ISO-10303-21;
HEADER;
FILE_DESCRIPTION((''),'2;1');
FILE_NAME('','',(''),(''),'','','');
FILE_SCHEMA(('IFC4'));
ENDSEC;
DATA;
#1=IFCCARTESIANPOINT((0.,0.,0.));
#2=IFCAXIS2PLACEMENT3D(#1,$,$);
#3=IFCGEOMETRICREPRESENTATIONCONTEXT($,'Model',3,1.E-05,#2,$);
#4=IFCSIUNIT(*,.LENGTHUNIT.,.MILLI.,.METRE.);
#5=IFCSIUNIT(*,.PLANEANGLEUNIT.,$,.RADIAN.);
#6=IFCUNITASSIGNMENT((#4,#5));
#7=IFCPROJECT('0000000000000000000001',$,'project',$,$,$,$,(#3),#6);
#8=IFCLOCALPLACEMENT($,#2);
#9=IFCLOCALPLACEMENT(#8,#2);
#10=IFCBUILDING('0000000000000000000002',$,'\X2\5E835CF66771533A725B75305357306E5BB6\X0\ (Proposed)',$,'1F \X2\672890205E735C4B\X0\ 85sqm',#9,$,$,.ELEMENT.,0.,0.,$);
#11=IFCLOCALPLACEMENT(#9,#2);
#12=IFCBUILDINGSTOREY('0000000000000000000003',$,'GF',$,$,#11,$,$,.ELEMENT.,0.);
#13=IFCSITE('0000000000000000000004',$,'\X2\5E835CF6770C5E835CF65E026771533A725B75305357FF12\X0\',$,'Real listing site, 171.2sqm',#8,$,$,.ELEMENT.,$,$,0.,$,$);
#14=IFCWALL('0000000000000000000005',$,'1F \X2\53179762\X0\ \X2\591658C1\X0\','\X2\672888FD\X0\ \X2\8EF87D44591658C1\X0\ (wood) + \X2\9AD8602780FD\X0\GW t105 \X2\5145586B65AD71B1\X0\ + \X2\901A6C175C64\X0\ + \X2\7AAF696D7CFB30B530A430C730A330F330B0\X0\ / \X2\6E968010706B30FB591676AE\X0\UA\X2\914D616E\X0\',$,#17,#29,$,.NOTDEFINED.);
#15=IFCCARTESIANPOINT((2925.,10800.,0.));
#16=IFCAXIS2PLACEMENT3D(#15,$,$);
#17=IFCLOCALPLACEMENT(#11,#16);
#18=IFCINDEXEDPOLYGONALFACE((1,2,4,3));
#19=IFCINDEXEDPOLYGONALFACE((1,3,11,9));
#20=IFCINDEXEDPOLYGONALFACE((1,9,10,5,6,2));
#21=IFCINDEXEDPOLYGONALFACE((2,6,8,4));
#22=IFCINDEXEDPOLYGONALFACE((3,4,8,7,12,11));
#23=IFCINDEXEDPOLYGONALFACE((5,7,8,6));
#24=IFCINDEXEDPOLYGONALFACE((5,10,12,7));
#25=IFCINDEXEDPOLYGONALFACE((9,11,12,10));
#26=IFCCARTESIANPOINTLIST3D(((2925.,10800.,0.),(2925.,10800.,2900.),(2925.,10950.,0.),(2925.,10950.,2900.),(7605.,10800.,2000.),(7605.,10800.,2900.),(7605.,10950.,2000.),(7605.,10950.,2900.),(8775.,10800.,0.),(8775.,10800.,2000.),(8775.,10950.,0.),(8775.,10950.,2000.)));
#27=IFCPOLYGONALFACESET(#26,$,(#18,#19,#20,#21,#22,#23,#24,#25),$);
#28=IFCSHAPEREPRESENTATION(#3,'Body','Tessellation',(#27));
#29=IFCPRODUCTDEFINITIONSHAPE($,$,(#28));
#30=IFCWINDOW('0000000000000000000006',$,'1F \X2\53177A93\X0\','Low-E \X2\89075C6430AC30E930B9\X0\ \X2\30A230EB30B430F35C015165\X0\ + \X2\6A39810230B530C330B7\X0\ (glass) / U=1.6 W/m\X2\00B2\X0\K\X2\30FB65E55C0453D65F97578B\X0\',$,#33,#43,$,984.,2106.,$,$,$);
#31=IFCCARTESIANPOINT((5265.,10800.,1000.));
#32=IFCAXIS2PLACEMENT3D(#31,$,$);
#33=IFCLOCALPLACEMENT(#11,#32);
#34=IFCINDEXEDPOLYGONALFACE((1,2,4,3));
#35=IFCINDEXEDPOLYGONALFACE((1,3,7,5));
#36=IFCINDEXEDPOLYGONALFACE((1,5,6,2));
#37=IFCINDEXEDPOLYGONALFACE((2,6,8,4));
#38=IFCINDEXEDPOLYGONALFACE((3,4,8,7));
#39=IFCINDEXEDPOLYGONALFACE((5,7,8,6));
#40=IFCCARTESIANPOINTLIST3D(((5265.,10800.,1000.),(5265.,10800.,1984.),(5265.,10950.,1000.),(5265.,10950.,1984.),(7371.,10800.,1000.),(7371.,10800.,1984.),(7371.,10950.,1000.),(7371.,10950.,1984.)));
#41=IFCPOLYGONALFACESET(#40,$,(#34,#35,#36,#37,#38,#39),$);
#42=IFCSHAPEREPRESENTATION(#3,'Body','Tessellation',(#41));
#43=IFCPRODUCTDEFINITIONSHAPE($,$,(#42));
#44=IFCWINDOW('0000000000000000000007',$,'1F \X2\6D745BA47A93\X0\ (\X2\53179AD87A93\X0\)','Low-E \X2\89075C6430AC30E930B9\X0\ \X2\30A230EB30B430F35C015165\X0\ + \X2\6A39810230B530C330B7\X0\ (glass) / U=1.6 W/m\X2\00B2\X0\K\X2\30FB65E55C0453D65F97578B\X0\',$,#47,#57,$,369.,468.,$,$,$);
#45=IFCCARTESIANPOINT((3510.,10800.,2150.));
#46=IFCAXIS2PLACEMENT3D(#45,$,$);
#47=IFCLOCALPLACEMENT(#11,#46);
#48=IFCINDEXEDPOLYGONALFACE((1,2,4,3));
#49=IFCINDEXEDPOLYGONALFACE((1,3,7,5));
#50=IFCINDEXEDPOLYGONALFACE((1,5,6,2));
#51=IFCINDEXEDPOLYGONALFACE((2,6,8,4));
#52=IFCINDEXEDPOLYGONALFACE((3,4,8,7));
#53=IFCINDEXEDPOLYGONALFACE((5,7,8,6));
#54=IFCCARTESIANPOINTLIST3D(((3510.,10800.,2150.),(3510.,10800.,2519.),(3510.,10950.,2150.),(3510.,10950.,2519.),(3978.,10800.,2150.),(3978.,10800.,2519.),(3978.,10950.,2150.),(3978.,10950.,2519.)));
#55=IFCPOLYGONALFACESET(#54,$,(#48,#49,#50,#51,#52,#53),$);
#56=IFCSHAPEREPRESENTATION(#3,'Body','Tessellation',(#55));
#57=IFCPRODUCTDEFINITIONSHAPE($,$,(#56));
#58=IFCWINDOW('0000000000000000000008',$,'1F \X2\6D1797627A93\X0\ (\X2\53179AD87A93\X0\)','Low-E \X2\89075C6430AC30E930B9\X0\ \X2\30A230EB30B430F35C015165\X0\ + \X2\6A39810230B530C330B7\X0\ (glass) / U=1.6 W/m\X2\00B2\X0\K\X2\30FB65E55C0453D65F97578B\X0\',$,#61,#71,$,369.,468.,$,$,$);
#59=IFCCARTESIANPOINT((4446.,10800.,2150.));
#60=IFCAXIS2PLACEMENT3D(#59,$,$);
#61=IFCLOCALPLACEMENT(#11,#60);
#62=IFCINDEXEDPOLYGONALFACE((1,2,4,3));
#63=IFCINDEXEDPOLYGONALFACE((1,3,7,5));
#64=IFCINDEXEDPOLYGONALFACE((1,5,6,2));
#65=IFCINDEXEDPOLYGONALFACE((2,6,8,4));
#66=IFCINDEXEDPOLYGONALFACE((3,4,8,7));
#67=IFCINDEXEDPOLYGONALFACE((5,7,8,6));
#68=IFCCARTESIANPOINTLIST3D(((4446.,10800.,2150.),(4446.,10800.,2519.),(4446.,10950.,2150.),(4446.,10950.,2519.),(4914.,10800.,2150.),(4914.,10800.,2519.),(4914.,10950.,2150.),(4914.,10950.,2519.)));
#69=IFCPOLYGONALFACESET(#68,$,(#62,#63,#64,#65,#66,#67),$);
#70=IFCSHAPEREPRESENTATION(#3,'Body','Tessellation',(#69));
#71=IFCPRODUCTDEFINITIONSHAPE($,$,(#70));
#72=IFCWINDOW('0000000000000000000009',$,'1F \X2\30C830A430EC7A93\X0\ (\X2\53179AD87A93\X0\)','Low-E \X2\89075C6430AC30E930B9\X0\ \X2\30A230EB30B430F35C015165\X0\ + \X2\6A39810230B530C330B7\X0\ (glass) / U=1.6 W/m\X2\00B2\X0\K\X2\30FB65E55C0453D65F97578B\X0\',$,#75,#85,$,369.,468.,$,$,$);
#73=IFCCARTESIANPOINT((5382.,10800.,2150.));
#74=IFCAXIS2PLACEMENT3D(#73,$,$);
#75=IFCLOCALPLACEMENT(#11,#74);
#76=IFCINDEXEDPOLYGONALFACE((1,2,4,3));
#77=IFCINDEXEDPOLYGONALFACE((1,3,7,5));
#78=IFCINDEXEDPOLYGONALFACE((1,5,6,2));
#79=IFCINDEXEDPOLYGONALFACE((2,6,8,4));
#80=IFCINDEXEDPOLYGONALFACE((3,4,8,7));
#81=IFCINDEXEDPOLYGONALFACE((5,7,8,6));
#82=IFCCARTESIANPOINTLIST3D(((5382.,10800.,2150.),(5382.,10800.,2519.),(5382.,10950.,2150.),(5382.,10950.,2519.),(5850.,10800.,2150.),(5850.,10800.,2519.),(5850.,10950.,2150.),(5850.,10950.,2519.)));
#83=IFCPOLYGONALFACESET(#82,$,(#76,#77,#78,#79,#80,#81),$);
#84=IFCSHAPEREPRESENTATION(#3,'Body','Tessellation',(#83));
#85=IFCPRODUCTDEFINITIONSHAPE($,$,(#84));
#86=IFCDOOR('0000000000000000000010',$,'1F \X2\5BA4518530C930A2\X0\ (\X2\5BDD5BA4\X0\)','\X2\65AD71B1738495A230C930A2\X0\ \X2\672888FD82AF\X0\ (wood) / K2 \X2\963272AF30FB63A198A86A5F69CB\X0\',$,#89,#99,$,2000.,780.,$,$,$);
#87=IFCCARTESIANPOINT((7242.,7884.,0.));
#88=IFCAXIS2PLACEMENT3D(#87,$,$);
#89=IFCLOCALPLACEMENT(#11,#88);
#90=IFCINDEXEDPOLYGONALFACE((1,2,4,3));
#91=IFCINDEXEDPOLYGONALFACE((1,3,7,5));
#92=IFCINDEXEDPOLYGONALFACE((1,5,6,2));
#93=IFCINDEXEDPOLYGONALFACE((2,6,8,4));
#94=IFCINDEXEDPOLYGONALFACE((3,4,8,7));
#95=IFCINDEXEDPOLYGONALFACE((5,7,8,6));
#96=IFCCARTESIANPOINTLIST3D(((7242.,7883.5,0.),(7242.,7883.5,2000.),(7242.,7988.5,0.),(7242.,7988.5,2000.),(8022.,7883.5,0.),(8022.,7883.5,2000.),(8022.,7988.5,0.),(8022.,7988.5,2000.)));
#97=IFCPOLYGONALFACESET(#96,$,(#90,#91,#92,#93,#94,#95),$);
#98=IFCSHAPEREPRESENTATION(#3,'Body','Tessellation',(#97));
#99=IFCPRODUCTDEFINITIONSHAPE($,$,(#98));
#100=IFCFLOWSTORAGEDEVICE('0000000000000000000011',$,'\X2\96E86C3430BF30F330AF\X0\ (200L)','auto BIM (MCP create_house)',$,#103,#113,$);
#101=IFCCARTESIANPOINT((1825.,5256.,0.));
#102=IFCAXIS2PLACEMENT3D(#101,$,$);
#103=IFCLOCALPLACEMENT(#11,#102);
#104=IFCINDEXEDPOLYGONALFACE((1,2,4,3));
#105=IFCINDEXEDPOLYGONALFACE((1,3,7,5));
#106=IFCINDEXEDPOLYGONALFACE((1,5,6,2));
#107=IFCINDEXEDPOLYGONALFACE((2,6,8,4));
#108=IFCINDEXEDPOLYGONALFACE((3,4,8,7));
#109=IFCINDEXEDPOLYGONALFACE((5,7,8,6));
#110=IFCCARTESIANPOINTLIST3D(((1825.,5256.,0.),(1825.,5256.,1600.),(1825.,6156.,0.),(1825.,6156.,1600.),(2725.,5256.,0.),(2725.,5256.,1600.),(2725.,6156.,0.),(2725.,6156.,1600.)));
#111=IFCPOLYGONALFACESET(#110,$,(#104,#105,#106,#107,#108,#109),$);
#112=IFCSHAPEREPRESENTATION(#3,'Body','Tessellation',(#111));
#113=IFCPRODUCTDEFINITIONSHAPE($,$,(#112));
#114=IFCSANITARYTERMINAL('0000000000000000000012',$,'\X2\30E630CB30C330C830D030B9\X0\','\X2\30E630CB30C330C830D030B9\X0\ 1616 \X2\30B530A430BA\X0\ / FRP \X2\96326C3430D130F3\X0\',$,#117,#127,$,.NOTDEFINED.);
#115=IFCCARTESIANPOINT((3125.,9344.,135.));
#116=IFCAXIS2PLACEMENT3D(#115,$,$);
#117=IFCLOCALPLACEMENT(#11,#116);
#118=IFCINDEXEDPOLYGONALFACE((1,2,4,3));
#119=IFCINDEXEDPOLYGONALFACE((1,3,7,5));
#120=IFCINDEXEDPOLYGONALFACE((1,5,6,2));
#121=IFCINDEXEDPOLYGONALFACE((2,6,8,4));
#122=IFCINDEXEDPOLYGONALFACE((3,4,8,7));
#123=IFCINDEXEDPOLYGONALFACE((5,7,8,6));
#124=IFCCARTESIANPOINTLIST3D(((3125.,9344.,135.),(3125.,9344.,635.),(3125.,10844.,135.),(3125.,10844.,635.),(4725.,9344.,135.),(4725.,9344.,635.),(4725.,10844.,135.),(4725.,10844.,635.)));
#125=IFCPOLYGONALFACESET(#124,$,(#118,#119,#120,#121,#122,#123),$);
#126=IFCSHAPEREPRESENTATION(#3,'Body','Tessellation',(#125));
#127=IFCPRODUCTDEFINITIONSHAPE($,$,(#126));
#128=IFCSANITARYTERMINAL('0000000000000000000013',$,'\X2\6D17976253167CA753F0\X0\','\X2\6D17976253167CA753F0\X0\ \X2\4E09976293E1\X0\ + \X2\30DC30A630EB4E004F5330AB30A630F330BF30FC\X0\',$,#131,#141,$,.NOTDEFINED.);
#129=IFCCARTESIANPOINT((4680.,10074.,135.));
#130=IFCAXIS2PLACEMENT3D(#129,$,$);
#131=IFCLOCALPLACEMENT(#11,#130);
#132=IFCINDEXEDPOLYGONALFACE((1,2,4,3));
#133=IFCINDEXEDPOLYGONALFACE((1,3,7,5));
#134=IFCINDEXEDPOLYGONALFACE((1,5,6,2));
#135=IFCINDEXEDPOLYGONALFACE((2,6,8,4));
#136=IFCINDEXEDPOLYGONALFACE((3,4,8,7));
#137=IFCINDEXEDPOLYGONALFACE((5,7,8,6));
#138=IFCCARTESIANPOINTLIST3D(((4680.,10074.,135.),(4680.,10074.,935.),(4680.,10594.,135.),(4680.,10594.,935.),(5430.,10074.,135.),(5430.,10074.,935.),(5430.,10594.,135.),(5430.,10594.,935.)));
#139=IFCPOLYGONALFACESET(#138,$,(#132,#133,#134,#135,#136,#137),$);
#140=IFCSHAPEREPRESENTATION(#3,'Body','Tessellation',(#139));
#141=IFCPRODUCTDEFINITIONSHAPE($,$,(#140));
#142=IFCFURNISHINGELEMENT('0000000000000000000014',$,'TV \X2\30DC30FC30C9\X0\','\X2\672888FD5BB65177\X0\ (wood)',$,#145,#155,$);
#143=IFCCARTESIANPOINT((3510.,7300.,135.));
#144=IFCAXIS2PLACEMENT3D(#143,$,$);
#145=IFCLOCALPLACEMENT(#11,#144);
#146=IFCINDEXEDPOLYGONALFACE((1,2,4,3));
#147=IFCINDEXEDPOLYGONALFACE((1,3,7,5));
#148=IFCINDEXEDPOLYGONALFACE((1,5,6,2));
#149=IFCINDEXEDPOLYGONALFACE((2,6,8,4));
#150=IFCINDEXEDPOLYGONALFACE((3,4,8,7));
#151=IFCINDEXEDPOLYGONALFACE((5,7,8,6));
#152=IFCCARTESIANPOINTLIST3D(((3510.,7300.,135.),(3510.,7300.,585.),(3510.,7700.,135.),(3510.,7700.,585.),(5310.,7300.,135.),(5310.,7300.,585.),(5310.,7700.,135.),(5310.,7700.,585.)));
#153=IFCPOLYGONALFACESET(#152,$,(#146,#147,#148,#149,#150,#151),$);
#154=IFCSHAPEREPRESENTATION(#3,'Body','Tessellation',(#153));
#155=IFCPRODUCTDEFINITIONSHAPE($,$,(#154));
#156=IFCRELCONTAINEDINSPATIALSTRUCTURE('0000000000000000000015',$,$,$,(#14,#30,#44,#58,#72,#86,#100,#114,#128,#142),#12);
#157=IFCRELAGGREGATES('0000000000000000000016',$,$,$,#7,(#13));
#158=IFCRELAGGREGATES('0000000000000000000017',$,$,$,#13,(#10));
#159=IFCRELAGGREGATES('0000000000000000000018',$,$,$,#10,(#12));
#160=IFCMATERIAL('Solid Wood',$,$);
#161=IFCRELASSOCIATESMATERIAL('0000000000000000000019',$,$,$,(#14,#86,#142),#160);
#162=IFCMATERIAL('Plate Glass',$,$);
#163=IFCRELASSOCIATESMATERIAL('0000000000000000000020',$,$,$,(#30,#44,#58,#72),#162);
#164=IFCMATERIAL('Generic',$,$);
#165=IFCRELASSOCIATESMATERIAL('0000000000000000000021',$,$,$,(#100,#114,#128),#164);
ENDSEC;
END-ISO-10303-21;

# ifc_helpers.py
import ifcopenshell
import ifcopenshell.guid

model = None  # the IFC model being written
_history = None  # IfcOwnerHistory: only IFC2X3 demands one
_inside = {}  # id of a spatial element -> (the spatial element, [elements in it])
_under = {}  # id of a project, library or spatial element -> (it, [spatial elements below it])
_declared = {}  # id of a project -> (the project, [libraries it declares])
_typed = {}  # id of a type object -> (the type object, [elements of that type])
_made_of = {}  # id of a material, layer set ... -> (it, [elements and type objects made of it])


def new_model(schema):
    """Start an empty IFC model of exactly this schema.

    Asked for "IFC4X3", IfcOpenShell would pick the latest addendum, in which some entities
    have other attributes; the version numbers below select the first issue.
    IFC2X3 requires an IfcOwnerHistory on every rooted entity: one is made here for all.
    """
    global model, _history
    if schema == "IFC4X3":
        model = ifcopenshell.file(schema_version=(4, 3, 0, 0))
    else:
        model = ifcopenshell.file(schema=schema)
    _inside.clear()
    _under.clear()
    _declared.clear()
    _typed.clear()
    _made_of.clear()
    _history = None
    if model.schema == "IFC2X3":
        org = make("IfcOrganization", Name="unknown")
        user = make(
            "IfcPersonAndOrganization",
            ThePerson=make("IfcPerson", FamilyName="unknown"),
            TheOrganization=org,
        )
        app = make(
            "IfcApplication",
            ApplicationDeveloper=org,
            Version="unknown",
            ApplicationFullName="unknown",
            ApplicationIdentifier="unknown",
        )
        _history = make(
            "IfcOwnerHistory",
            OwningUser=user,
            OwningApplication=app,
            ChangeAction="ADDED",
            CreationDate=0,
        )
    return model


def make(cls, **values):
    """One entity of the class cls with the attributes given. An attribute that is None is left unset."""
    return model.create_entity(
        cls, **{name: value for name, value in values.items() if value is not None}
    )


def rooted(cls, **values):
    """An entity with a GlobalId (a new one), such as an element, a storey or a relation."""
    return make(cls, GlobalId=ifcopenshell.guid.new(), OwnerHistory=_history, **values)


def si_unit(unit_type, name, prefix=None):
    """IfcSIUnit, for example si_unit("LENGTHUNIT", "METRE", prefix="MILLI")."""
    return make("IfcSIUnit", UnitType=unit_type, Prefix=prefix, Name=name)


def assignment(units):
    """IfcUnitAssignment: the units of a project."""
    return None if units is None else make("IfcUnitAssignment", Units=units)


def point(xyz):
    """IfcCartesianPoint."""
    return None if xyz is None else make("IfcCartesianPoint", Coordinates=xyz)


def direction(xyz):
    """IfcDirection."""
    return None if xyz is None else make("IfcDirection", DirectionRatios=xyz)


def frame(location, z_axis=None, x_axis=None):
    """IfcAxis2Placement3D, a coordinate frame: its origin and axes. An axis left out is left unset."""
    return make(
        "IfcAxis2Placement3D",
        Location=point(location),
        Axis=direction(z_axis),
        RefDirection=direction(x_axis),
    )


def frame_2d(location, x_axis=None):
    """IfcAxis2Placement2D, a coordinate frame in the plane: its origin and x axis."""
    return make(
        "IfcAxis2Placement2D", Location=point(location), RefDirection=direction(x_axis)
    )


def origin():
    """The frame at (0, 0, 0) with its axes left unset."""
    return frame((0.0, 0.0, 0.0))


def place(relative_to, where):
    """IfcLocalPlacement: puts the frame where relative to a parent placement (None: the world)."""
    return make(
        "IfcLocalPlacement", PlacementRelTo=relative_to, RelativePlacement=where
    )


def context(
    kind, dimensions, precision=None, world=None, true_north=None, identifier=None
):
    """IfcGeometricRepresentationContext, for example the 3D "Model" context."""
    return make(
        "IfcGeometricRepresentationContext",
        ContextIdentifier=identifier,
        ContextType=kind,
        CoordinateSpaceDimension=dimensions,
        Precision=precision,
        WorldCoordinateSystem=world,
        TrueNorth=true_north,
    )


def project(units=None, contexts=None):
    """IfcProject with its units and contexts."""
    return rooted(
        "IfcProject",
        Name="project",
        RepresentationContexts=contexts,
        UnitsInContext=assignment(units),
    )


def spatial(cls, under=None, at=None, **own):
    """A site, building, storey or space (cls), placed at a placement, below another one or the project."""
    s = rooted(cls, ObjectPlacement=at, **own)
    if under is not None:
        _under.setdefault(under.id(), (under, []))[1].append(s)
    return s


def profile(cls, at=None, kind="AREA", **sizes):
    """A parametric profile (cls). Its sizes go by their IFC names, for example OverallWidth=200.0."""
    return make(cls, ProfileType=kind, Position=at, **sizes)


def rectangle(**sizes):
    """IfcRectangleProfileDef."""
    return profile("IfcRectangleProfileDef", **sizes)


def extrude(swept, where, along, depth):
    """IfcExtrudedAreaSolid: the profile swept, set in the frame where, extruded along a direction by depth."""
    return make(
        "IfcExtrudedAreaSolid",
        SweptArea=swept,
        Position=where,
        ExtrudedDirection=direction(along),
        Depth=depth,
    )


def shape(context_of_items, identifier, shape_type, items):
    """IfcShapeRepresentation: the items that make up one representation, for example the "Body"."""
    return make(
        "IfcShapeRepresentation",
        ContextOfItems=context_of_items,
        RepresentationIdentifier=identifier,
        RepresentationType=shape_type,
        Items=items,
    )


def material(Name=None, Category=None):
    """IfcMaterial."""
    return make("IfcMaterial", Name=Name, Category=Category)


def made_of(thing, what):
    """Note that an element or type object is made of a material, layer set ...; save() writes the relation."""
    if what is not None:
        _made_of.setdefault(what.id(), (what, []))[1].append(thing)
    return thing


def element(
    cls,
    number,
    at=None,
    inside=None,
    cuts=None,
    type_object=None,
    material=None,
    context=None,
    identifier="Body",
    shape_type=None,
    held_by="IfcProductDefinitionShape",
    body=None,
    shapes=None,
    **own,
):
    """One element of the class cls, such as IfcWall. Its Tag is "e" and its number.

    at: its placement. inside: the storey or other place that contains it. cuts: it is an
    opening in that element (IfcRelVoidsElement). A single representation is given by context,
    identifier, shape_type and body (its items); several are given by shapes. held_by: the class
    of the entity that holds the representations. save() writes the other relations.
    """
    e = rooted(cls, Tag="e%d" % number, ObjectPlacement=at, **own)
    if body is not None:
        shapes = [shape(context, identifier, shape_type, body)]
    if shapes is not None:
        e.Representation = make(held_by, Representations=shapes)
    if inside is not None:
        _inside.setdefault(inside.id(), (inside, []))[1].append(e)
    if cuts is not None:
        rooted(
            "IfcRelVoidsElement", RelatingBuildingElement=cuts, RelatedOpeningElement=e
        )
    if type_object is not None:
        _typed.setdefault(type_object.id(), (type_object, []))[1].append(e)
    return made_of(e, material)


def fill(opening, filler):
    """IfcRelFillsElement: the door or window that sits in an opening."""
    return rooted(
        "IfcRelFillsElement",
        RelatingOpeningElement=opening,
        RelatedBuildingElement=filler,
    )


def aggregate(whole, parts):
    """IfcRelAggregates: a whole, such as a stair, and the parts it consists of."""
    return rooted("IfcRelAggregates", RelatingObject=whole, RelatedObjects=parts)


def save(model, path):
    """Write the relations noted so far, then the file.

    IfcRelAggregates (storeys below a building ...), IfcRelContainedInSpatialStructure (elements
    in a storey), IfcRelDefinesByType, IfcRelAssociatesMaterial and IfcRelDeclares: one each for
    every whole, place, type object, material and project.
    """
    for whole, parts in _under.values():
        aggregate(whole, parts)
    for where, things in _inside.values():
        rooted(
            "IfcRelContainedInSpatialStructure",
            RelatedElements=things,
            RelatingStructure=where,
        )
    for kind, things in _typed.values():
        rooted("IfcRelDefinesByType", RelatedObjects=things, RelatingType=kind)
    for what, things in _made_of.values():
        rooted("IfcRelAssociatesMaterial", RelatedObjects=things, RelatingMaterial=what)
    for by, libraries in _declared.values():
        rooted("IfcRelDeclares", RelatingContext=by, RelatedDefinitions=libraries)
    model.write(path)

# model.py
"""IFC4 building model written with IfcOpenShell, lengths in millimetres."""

from ifc_helpers import new_model, si_unit, frame, frame_2d, origin, place, context, project, spatial, rectangle, extrude, material, element, fill, save


model = new_model("IFC4")

# Units and contexts
model_context = context("Model", 3, precision=1e-05, world=origin())
ifc_project = project(units=[si_unit("LENGTHUNIT", "METRE", prefix="MILLI"), si_unit("PLANEANGLEUNIT", "RADIAN")], contexts=[model_context])

# Site, building, storey
site_placement = place(None, origin())
site = spatial("IfcSite", under=ifc_project, at=site_placement, Name="広島県広島市東区牛田南２", ObjectType="Real listing site, 171.2sqm", CompositionType="ELEMENT", RefElevation=0.0)
building_placement = place(site_placement, origin())
building = spatial("IfcBuilding", under=site, at=building_placement, Name="広島東区牛田南の家 (Proposed)", ObjectType="1F 木造平屋 85sqm", CompositionType="ELEMENT", ElevationOfRefHeight=0.0, ElevationOfTerrain=0.0)
storey_placement = place(building_placement, origin())
storey = spatial("IfcBuildingStorey", under=building, at=storey_placement, Name="GF", CompositionType="ELEMENT", Elevation=0.0)

# Wall, openings, windows
ifc_material_1 = material(Name="Solid Wood")
wall_1_placement = place(storey_placement, frame((2925.0, 10800.0, 0.0)))
wall_1 = element("IfcWall", 1, at=wall_1_placement, inside=storey, material=ifc_material_1, Name="1F 北面 外壁", Description="木製 軸組外壁 (wood) + 高性能GW t105 充填断熱 + 通気層 + 窯業系サイディング / 準耐火・外皮UA配慮", PredefinedType="NOTDEFINED", context=model_context, shape_type="SweptSolid", body=[
    extrude(rectangle(XDim=5850.0, YDim=150.0, at=frame_2d((2925.0, 75.0))), frame((2925.0, 10800.0, 0.0)), (0.0, 0.0, 1.0), 2900.0),
])
opening_1_placement = place(storey_placement, frame((5265.0, 10800.0, 1000.0)))
opening_1 = element("IfcOpeningElement", 2, at=opening_1_placement, cuts=wall_1, PredefinedType="NOTDEFINED", context=model_context, shape_type="SweptSolid", body=[
    extrude(rectangle(XDim=2106.0, YDim=150.0, at=frame_2d((1053.0, 75.0))), frame((5265.0, 10800.0, 1000.0)), (0.0, 0.0, 1.0), 984.0),
])
opening_2_placement = place(storey_placement, frame((3510.0, 10800.0, 2150.0)))
opening_2 = element("IfcOpeningElement", 3, at=opening_2_placement, cuts=wall_1, PredefinedType="NOTDEFINED", context=model_context, shape_type="SweptSolid", body=[
    extrude(rectangle(XDim=468.0, YDim=150.0, at=frame_2d((234.0, 75.0))), frame((3510.0, 10800.0, 2150.0)), (0.0, 0.0, 1.0), 369.0),
])
opening_3_placement = place(storey_placement, frame((4446.0, 10800.0, 2150.0)))
opening_3 = element("IfcOpeningElement", 4, at=opening_3_placement, cuts=wall_1, PredefinedType="NOTDEFINED", context=model_context, shape_type="SweptSolid", body=[
    extrude(rectangle(XDim=468.0, YDim=150.0, at=frame_2d((234.0, 75.0))), frame((4446.0, 10800.0, 2150.0)), (0.0, 0.0, 1.0), 369.0),
])
opening_4_placement = place(storey_placement, frame((5382.0, 10800.0, 2150.0)))
opening_4 = element("IfcOpeningElement", 5, at=opening_4_placement, cuts=wall_1, PredefinedType="NOTDEFINED", context=model_context, shape_type="SweptSolid", body=[
    extrude(rectangle(XDim=468.0, YDim=150.0, at=frame_2d((234.0, 75.0))), frame((5382.0, 10800.0, 2150.0)), (0.0, 0.0, 1.0), 369.0),
])
ifc_material_2 = material(Name="Plate Glass")
window_1_placement = place(storey_placement, frame((5265.0, 10800.0, 1000.0)))
window_1 = element("IfcWindow", 6, at=window_1_placement, inside=storey, material=ifc_material_2, Name="1F 北窓", Description="Low-E 複層ガラス アルゴン封入 + 樹脂サッシ (glass) / U=1.6 W/m²K・日射取得型", OverallHeight=984.0, OverallWidth=2106.0, context=model_context, shape_type="SweptSolid", body=[
    extrude(rectangle(XDim=2106.0, YDim=150.0, at=frame_2d((1053.0, 75.0))), frame((5265.0, 10800.0, 1000.0)), (0.0, 0.0, 1.0), 984.0),
])
fill(opening_1, window_1)
window_2_placement = place(storey_placement, frame((3510.0, 10800.0, 2150.0)))
window_2 = element("IfcWindow", 7, at=window_2_placement, inside=storey, material=ifc_material_2, Name="1F 浴室窓 (北高窓)", Description="Low-E 複層ガラス アルゴン封入 + 樹脂サッシ (glass) / U=1.6 W/m²K・日射取得型", OverallHeight=369.0, OverallWidth=468.0, context=model_context, shape_type="SweptSolid", body=[
    extrude(rectangle(XDim=468.0, YDim=150.0, at=frame_2d((234.0, 75.0))), frame((3510.0, 10800.0, 2150.0)), (0.0, 0.0, 1.0), 369.0),
])
fill(opening_2, window_2)
window_3_placement = place(storey_placement, frame((4446.0, 10800.0, 2150.0)))
window_3 = element("IfcWindow", 8, at=window_3_placement, inside=storey, material=ifc_material_2, Name="1F 洗面窓 (北高窓)", Description="Low-E 複層ガラス アルゴン封入 + 樹脂サッシ (glass) / U=1.6 W/m²K・日射取得型", OverallHeight=369.0, OverallWidth=468.0, context=model_context, shape_type="SweptSolid", body=[
    extrude(rectangle(XDim=468.0, YDim=150.0, at=frame_2d((234.0, 75.0))), frame((4446.0, 10800.0, 2150.0)), (0.0, 0.0, 1.0), 369.0),
])
fill(opening_3, window_3)
window_4_placement = place(storey_placement, frame((5382.0, 10800.0, 2150.0)))
window_4 = element("IfcWindow", 9, at=window_4_placement, inside=storey, material=ifc_material_2, Name="1F トイレ窓 (北高窓)", Description="Low-E 複層ガラス アルゴン封入 + 樹脂サッシ (glass) / U=1.6 W/m²K・日射取得型", OverallHeight=369.0, OverallWidth=468.0, context=model_context, shape_type="SweptSolid", body=[
    extrude(rectangle(XDim=468.0, YDim=150.0, at=frame_2d((234.0, 75.0))), frame((5382.0, 10800.0, 2150.0)), (0.0, 0.0, 1.0), 369.0),
])
fill(opening_4, window_4)

# Door
door_1_placement = place(storey_placement, frame((7242.0, 7884.0, 0.0)))
element("IfcDoor", 10, at=door_1_placement, inside=storey, material=ifc_material_1, Name="1F 室内ドア (寝室)", Description="断熱玄関ドア 木製芯 (wood) / K2 防犯・採風機構", OverallHeight=2000.0, OverallWidth=780.0, context=model_context, shape_type="SweptSolid", body=[
    extrude(rectangle(XDim=780.0, YDim=105.0, at=frame_2d((390.0, 52.0))), frame((7242.0, 7884.0, 0.0)), (0.0, 0.0, 1.0), 2000.0),
])

# Flow storage device
ifc_material_3 = material(Name="Generic")
flow_storage_device_placement = place(storey_placement, frame((1825.0, 5256.0, 0.0)))
element("IfcFlowStorageDevice", 11, at=flow_storage_device_placement, inside=storey, material=ifc_material_3, Name="雨水タンク (200L)", Description="auto BIM (MCP create_house)", context=model_context, shape_type="SweptSolid", body=[
    extrude(rectangle(XDim=900.0, YDim=900.0, at=frame_2d((450.0, 450.0))), frame((1825.0, 5256.0, 0.0)), (0.0, 0.0, 1.0), 1600.0),
])

# Sanitary terminals
sanitary_terminal_1_placement = place(storey_placement, frame((3125.0, 9344.0, 135.0)))
element("IfcSanitaryTerminal", 12, at=sanitary_terminal_1_placement, inside=storey, material=ifc_material_3, Name="ユニットバス", Description="ユニットバス 1616 サイズ / FRP 防水パン", PredefinedType="NOTDEFINED", context=model_context, shape_type="SweptSolid", body=[
    extrude(rectangle(XDim=1600.0, YDim=1500.0, at=frame_2d((800.0, 750.0))), frame((3125.0, 9344.0, 135.0)), (0.0, 0.0, 1.0), 500.0),
])
sanitary_terminal_2_placement = place(storey_placement, frame((4680.0, 10074.0, 135.0)))
element("IfcSanitaryTerminal", 13, at=sanitary_terminal_2_placement, inside=storey, material=ifc_material_3, Name="洗面化粧台", Description="洗面化粧台 三面鏡 + ボウル一体カウンター", PredefinedType="NOTDEFINED", context=model_context, shape_type="SweptSolid", body=[
    extrude(rectangle(XDim=750.0, YDim=520.0, at=frame_2d((375.0, 260.0))), frame((4680.0, 10074.0, 135.0)), (0.0, 0.0, 1.0), 800.0),
])

# Furnishing element
furnishing_placement = place(storey_placement, frame((3510.0, 7300.0, 135.0)))
element("IfcFurnishingElement", 14, at=furnishing_placement, inside=storey, material=ifc_material_1, Name="TV ボード", Description="木製家具 (wood)", context=model_context, shape_type="SweptSolid", body=[
    extrude(rectangle(XDim=1800.0, YDim=400.0, at=frame_2d((900.0, 200.0))), frame((3510.0, 7300.0, 135.0)), (0.0, 0.0, 1.0), 450.0),
])

save(model, "model.ifc")
